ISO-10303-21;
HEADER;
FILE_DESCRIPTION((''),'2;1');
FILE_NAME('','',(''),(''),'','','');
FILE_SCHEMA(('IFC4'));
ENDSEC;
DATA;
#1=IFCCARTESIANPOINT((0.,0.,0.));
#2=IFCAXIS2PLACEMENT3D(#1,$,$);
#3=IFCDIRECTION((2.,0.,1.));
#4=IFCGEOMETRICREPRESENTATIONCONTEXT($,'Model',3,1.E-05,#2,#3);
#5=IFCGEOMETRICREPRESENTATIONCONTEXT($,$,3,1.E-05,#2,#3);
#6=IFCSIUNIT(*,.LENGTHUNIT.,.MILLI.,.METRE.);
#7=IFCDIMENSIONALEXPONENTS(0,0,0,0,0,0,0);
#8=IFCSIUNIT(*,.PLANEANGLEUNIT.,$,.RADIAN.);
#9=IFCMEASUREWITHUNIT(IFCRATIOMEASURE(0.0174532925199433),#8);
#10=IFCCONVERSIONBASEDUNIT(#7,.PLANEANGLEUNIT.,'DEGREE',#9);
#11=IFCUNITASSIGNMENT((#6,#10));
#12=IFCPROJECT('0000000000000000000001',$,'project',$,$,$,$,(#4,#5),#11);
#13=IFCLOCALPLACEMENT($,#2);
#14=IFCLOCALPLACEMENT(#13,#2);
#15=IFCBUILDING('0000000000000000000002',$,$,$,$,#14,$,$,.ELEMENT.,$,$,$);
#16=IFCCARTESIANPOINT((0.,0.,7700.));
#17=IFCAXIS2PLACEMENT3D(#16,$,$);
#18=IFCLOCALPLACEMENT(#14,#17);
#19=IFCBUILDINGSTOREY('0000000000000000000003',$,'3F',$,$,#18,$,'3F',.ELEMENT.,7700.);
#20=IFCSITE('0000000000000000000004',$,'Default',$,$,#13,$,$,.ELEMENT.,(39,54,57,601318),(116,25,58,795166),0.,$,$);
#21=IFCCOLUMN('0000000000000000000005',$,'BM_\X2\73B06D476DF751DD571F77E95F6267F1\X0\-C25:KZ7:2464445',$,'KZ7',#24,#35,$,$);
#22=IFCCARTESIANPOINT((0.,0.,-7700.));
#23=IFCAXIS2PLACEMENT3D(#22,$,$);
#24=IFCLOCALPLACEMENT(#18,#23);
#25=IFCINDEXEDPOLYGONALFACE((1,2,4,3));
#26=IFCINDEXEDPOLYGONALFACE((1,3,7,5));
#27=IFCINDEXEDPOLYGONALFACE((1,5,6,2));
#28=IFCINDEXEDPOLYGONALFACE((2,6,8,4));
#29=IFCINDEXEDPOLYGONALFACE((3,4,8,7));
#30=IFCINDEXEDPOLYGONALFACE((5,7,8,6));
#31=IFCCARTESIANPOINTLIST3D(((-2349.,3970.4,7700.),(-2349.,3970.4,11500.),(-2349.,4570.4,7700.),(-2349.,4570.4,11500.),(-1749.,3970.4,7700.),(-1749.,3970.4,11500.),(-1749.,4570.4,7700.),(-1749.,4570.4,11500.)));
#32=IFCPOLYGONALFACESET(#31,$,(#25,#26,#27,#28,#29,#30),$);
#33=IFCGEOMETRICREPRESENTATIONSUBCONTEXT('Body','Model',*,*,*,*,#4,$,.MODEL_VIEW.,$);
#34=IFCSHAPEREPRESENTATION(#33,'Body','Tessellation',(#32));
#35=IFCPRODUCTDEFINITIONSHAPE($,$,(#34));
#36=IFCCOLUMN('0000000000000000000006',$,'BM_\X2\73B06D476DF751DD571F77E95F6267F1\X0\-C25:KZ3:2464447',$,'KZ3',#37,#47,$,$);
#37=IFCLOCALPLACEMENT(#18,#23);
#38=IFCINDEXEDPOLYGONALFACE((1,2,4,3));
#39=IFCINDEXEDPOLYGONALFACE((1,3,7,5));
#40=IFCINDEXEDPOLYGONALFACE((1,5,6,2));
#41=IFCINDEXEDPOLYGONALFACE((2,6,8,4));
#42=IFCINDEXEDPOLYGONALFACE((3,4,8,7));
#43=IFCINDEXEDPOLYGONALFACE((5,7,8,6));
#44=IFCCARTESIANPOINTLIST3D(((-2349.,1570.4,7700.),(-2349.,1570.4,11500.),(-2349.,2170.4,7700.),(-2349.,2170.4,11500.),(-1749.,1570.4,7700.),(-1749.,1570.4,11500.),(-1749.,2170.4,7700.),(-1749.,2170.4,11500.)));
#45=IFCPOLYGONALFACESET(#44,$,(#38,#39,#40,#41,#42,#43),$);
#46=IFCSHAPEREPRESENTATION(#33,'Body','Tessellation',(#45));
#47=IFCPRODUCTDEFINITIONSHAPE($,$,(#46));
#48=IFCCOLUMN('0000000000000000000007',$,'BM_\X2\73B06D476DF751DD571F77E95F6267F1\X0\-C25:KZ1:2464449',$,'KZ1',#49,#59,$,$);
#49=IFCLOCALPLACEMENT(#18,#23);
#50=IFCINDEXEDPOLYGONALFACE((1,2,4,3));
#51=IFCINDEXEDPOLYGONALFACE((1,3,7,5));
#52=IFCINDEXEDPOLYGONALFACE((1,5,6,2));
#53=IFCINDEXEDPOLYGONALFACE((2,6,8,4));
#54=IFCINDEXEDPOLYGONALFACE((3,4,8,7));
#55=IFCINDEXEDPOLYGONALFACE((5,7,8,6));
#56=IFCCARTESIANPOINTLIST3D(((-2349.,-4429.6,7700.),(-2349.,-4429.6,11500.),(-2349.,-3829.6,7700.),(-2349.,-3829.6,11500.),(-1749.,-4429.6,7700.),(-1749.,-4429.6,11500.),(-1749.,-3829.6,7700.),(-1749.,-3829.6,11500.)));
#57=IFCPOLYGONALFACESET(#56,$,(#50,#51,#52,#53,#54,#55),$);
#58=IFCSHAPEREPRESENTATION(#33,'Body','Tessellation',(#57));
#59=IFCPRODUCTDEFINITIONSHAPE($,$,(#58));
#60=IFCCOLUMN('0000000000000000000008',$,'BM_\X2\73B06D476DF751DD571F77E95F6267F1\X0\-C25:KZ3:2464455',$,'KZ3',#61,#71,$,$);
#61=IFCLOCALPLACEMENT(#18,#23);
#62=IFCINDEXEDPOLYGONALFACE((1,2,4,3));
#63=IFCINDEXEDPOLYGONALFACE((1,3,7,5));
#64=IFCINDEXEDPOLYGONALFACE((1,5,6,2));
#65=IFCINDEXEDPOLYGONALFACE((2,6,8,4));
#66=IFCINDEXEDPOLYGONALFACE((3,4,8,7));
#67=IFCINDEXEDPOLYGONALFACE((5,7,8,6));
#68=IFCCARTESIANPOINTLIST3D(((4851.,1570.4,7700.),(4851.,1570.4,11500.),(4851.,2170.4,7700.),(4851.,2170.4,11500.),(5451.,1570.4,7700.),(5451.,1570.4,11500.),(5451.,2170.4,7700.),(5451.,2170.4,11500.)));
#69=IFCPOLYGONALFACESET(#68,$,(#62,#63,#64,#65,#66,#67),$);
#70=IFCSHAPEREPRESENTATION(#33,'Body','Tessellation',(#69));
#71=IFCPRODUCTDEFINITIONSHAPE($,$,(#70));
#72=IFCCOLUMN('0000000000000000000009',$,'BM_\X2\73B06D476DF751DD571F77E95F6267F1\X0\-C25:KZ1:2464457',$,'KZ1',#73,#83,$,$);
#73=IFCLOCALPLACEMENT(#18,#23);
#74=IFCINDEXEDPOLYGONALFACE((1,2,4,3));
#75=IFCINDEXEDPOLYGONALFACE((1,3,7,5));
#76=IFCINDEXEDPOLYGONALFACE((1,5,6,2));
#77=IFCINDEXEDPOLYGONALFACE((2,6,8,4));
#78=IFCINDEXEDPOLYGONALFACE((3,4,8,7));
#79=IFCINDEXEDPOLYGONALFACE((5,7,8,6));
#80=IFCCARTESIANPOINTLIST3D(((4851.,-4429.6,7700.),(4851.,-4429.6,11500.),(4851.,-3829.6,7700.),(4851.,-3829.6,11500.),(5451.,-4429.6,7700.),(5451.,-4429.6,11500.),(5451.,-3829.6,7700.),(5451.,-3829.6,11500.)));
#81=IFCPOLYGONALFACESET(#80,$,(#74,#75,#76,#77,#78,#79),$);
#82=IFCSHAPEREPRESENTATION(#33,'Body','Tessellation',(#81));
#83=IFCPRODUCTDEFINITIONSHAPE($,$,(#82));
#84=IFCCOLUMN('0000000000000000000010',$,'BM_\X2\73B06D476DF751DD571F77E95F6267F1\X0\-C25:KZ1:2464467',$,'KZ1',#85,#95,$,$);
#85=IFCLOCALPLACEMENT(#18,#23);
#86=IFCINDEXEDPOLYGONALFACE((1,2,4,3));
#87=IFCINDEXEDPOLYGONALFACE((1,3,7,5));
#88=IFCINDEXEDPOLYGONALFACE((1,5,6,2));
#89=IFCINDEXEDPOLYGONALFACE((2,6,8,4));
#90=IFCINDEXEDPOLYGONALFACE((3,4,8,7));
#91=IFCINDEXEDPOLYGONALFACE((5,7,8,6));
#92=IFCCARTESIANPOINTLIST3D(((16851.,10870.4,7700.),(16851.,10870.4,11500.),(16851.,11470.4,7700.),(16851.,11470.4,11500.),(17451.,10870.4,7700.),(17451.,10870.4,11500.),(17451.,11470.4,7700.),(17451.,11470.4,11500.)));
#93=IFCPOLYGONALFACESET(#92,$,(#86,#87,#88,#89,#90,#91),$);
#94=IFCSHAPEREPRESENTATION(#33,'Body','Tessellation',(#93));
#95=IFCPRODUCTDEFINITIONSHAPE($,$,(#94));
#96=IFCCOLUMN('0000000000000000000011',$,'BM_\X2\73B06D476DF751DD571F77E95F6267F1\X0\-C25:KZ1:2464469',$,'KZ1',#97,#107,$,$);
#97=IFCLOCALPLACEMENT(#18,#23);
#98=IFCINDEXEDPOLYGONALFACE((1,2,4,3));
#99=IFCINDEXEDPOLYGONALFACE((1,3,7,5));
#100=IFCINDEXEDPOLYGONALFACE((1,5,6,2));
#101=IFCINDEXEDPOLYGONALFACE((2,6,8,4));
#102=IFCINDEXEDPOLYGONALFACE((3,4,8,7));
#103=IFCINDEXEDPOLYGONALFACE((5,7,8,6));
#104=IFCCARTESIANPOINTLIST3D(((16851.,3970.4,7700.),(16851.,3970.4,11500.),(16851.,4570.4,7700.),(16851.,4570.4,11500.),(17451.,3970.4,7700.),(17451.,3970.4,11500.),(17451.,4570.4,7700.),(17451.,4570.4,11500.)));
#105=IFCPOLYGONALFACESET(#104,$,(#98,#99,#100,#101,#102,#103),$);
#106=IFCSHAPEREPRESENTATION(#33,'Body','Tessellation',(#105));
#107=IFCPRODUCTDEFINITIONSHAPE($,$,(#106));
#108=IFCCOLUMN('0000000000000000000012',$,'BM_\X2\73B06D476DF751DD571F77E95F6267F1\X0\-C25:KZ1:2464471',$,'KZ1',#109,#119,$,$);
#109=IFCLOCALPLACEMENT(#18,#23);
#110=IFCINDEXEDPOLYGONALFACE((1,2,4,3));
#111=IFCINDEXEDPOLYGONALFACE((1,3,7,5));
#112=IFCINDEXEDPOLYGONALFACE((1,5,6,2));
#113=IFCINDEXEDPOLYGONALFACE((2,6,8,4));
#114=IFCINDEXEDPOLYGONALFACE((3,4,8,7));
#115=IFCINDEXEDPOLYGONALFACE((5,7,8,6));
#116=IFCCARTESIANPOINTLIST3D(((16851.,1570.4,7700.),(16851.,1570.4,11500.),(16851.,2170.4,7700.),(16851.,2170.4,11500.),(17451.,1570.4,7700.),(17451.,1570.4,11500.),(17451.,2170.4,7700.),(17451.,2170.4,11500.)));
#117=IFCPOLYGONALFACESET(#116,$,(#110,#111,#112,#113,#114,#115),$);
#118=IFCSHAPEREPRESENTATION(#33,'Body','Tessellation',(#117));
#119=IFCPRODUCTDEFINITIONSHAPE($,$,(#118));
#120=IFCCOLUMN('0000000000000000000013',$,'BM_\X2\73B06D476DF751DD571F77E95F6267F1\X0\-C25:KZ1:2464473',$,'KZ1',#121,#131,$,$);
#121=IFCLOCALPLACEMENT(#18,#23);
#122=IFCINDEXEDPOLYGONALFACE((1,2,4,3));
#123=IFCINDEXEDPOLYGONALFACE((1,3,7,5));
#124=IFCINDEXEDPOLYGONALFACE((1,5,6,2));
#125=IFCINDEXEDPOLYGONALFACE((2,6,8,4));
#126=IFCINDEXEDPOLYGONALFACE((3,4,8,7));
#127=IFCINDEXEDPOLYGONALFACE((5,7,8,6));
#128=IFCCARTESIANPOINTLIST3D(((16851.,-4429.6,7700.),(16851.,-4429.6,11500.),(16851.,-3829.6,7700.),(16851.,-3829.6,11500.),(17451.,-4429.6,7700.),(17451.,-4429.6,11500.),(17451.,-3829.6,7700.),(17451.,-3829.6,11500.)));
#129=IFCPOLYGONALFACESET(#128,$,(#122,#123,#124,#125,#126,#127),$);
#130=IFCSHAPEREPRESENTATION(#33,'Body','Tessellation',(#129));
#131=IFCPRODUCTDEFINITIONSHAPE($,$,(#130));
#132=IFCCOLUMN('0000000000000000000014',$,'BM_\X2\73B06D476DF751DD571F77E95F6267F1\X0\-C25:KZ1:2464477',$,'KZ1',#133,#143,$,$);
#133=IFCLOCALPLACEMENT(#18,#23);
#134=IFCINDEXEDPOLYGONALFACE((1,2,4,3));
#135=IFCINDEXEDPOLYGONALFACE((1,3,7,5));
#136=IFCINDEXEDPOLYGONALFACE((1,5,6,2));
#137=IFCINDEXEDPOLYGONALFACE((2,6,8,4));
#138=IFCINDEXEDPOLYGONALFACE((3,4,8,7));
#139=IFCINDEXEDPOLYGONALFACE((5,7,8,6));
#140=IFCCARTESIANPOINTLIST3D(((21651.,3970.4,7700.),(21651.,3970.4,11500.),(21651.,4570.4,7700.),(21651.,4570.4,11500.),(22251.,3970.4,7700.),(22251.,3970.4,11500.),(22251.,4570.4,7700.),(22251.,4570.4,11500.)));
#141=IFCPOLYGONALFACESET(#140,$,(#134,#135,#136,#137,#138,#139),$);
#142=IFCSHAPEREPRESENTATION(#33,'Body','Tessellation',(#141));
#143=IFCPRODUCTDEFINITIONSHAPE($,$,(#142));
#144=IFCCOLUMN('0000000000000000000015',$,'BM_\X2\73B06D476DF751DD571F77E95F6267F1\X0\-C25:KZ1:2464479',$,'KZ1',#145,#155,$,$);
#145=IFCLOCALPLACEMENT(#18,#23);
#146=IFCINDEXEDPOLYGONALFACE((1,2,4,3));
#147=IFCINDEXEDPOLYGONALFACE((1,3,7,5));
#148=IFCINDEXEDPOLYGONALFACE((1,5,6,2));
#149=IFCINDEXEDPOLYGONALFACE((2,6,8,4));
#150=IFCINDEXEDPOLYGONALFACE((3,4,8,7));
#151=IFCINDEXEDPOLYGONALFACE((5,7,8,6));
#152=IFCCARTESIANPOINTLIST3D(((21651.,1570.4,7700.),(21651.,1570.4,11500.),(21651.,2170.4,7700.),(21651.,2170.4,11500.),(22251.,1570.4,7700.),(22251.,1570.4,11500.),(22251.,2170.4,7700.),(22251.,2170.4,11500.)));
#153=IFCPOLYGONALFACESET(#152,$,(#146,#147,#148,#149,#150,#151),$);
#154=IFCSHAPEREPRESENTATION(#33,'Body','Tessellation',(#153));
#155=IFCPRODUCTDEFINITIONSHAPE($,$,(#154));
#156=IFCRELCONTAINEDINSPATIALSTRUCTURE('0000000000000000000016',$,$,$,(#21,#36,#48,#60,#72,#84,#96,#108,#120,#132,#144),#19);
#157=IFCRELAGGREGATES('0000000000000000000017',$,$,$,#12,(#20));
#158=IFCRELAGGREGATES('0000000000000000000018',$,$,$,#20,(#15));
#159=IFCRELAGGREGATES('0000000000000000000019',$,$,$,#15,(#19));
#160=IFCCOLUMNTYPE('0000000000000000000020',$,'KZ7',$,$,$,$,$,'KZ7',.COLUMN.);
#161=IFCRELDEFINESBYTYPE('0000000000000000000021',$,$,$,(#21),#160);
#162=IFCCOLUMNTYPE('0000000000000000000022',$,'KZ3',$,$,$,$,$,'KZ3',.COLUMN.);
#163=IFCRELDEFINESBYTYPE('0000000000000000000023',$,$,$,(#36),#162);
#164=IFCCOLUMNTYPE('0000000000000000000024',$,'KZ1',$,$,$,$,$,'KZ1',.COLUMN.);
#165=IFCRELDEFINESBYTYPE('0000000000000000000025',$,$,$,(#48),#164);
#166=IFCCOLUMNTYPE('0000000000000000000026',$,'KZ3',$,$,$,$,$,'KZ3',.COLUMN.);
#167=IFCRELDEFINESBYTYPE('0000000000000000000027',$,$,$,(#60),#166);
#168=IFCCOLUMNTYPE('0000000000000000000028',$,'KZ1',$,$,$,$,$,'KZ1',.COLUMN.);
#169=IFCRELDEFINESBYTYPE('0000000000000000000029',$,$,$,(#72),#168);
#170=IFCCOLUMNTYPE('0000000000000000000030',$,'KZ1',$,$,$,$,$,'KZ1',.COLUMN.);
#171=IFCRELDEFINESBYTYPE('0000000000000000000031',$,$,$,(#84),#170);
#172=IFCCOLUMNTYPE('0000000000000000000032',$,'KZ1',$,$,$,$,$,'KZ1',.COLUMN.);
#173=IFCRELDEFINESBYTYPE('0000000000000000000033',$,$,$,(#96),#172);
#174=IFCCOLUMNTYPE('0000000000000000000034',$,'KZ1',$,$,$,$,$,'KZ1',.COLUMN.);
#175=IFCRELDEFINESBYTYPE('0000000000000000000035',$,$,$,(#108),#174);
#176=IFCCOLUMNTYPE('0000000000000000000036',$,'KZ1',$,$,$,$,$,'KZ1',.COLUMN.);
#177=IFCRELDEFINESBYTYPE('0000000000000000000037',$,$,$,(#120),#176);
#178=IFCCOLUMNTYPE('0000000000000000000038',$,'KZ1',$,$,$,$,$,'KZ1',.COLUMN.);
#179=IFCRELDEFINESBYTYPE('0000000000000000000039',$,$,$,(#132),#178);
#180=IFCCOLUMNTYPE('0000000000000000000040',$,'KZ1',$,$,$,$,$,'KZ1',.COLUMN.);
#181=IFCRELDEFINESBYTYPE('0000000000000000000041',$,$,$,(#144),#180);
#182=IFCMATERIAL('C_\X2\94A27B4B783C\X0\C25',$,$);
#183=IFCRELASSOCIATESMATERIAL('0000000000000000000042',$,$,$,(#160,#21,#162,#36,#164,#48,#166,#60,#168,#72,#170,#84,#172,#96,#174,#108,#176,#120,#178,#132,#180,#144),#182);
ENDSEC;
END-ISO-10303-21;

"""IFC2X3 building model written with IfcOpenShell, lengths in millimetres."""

from ifc_helpers import new_model, entity, si_unit, converted_unit, direction, frame, frame_2d, origin, origin_2d_with_axis, place, context, subcontext, project, spatial, rectangle, extrude, source, transform, mapped, material, type_object, type_shapes, element, save


model = new_model("IFC2X3")

# Units and contexts
model_context = context("Model", 3, precision=1e-05, world=origin(), true_north=direction((2.0, 0.0, 1.0)))
context_of_model = context(None, 3, precision=1e-05, world=origin(), true_north=direction((2.0, 0.0, 1.0)))
body_context = subcontext(model_context, "Body", "Model", "MODEL_VIEW")
ifc_project = project(units=[si_unit("LENGTHUNIT", "METRE", prefix="MILLI"), converted_unit("PLANEANGLEUNIT", "DEGREE", entity("IfcRatioMeasure", 0.0174532925199433), si_unit("PLANEANGLEUNIT", "RADIAN"), dimensions=[0, 0, 0, 0, 0, 0, 0])], contexts=[model_context, context_of_model])

# Site, building, storey
site_placement = place(None, origin())
site = spatial("IfcSite", under=ifc_project, at=site_placement, Name="Default", CompositionType="ELEMENT", RefLatitude=(39, 54, 57, 601318), RefLongitude=(116, 25, 58, 795166), RefElevation=0.0)
building_placement = place(site_placement, origin())
building = spatial("IfcBuilding", under=site, at=building_placement, CompositionType="ELEMENT")
storey_placement = place(building_placement, frame((0.0, 0.0, 7700.0)))
storey = spatial("IfcBuildingStorey", under=building, at=storey_placement, Name="3F", LongName="3F", CompositionType="ELEMENT", Elevation=7700.0)

# Columns
ifc_material = material(Name="C_钢筋砼C25")
column_type_1 = type_object("IfcColumnType", Name="KZ7", ElementType="KZ7", PredefinedType="COLUMN", material=ifc_material)
shared_shape_1 = source(origin(), body_context, "Body", "SweptSolid", [
    extrude(rectangle(XDim=600.0, YDim=600.0, at=origin_2d_with_axis()), frame((-2049.0, 4270.4, 7700.0), z_axis=(0.0, 0.0, 1.0), x_axis=(-1.0, 0.0, 0.0)), (0.0, 0.0, 1.0), 3800.0),
])
type_shapes(column_type_1, [shared_shape_1])
column_1_placement = place(storey_placement, frame((0.0, 0.0, -7700.0)))
element("IfcColumn", 1, at=column_1_placement, inside=storey, type_object=column_type_1, material=ifc_material, Name="BM_现浇混凝土矩形柱-C25:KZ7:2464445", ObjectType="KZ7", context=body_context, shape_type="MappedRepresentation", body=[
    mapped(shared_shape_1, transform((0.0, 0.0, 0.0), scale=1.0)),
])
column_type_2 = type_object("IfcColumnType", Name="KZ3", ElementType="KZ3", PredefinedType="COLUMN", material=ifc_material)
shared_shape_2 = source(origin(), body_context, "Body", "SweptSolid", [
    extrude(rectangle(XDim=600.0, YDim=600.0, at=origin_2d_with_axis()), frame((-2049.0, 1870.4, 7700.0), z_axis=(0.0, 0.0, 1.0), x_axis=(-1.0, 0.0, 0.0)), (0.0, 0.0, 1.0), 3800.0),
])
type_shapes(column_type_2, [shared_shape_2])
column_2_placement = place(storey_placement, frame((0.0, 0.0, -7700.0)))
element("IfcColumn", 2, at=column_2_placement, inside=storey, type_object=column_type_2, material=ifc_material, Name="BM_现浇混凝土矩形柱-C25:KZ3:2464447", ObjectType="KZ3", context=body_context, shape_type="MappedRepresentation", body=[
    mapped(shared_shape_2, transform((0.0, 0.0, 0.0), scale=1.0)),
])
column_type_3 = type_object("IfcColumnType", Name="KZ1", ElementType="KZ1", PredefinedType="COLUMN", material=ifc_material)
shared_shape_3 = source(origin(), body_context, "Body", "SweptSolid", [
    extrude(rectangle(XDim=600.0, YDim=600.0, at=origin_2d_with_axis()), frame((-2049.0, -4129.6, 7700.0), z_axis=(0.0, 0.0, 1.0), x_axis=(-1.0, 0.0, 0.0)), (0.0, 0.0, 1.0), 3800.0),
])
type_shapes(column_type_3, [shared_shape_3])
column_3_placement = place(storey_placement, frame((0.0, 0.0, -7700.0)))
element("IfcColumn", 3, at=column_3_placement, inside=storey, type_object=column_type_3, material=ifc_material, Name="BM_现浇混凝土矩形柱-C25:KZ1:2464449", ObjectType="KZ1", context=body_context, shape_type="MappedRepresentation", body=[
    mapped(shared_shape_3, transform((0.0, 0.0, 0.0), scale=1.0)),
])
column_type_4 = type_object("IfcColumnType", Name="KZ3", ElementType="KZ3", PredefinedType="COLUMN", material=ifc_material)
shared_shape_4 = source(origin(), body_context, "Body", "SweptSolid", [
    extrude(rectangle(XDim=600.0, YDim=600.0, at=origin_2d_with_axis()), frame((5151.0, 1870.4, 7700.0), z_axis=(0.0, 0.0, 1.0), x_axis=(-1.0, 0.0, 0.0)), (0.0, 0.0, 1.0), 3800.0),
])
type_shapes(column_type_4, [shared_shape_4])
column_4_placement = place(storey_placement, frame((0.0, 0.0, -7700.0)))
element("IfcColumn", 4, at=column_4_placement, inside=storey, type_object=column_type_4, material=ifc_material, Name="BM_现浇混凝土矩形柱-C25:KZ3:2464455", ObjectType="KZ3", context=body_context, shape_type="MappedRepresentation", body=[
    mapped(shared_shape_4, transform((0.0, 0.0, 0.0), scale=1.0)),
])
column_type_5 = type_object("IfcColumnType", Name="KZ1", ElementType="KZ1", PredefinedType="COLUMN", material=ifc_material)
shared_shape_5 = source(origin(), body_context, "Body", "SweptSolid", [
    extrude(rectangle(XDim=600.0, YDim=600.0, at=origin_2d_with_axis()), frame((5151.0, -4129.6, 7700.0), z_axis=(0.0, 0.0, 1.0), x_axis=(-1.0, 0.0, 0.0)), (0.0, 0.0, 1.0), 3800.0),
])
type_shapes(column_type_5, [shared_shape_5])
column_5_placement = place(storey_placement, frame((0.0, 0.0, -7700.0)))
element("IfcColumn", 5, at=column_5_placement, inside=storey, type_object=column_type_5, material=ifc_material, Name="BM_现浇混凝土矩形柱-C25:KZ1:2464457", ObjectType="KZ1", context=body_context, shape_type="MappedRepresentation", body=[
    mapped(shared_shape_5, transform((0.0, 0.0, 0.0), scale=1.0)),
])
column_type_6 = type_object("IfcColumnType", Name="KZ1", ElementType="KZ1", PredefinedType="COLUMN", material=ifc_material)
shared_shape_6 = source(origin(), body_context, "Body", "SweptSolid", [
    extrude(rectangle(XDim=600.0, YDim=600.0, at=frame_2d((0.0, 0.0), x_axis=(1.0, 0.0))), frame((17151.0, 11170.4, 7700.0), z_axis=(0.0, 0.0, 1.0), x_axis=(-1.0, 0.0, 0.0)), (0.0, 0.0, 1.0), 3800.0),
])
type_shapes(column_type_6, [shared_shape_6])
column_6_placement = place(storey_placement, frame((0.0, 0.0, -7700.0)))
element("IfcColumn", 6, at=column_6_placement, inside=storey, type_object=column_type_6, material=ifc_material, Name="BM_现浇混凝土矩形柱-C25:KZ1:2464467", ObjectType="KZ1", context=body_context, shape_type="MappedRepresentation", body=[
    mapped(shared_shape_6, transform((0.0, 0.0, 0.0), scale=1.0)),
])
column_type_7 = type_object("IfcColumnType", Name="KZ1", ElementType="KZ1", PredefinedType="COLUMN", material=ifc_material)
shared_shape_7 = source(origin(), body_context, "Body", "SweptSolid", [
    extrude(rectangle(XDim=600.0, YDim=600.0, at=frame_2d((0.0, 0.0), x_axis=(1.0, 0.0))), frame((17151.0, 4270.4, 7700.0), z_axis=(0.0, 0.0, 1.0), x_axis=(-1.0, 0.0, 0.0)), (0.0, 0.0, 1.0), 3800.0),
])
type_shapes(column_type_7, [shared_shape_7])
column_7_placement = place(storey_placement, frame((0.0, 0.0, -7700.0)))
element("IfcColumn", 7, at=column_7_placement, inside=storey, type_object=column_type_7, material=ifc_material, Name="BM_现浇混凝土矩形柱-C25:KZ1:2464469", ObjectType="KZ1", context=body_context, shape_type="MappedRepresentation", body=[
    mapped(shared_shape_7, transform((0.0, 0.0, 0.0), scale=1.0)),
])
column_type_8 = type_object("IfcColumnType", Name="KZ1", ElementType="KZ1", PredefinedType="COLUMN", material=ifc_material)
shared_shape_8 = source(origin(), body_context, "Body", "SweptSolid", [
    extrude(rectangle(XDim=600.0, YDim=600.0, at=frame_2d((0.0, 0.0), x_axis=(1.0, 0.0))), frame((17151.0, 1870.4, 7700.0), z_axis=(0.0, 0.0, 1.0), x_axis=(-1.0, 0.0, 0.0)), (0.0, 0.0, 1.0), 3800.0),
])
type_shapes(column_type_8, [shared_shape_8])
column_8_placement = place(storey_placement, frame((0.0, 0.0, -7700.0)))
element("IfcColumn", 8, at=column_8_placement, inside=storey, type_object=column_type_8, material=ifc_material, Name="BM_现浇混凝土矩形柱-C25:KZ1:2464471", ObjectType="KZ1", context=body_context, shape_type="MappedRepresentation", body=[
    mapped(shared_shape_8, transform((0.0, 0.0, 0.0), scale=1.0)),
])
column_type_9 = type_object("IfcColumnType", Name="KZ1", ElementType="KZ1", PredefinedType="COLUMN", material=ifc_material)
shared_shape_9 = source(origin(), body_context, "Body", "SweptSolid", [
    extrude(rectangle(XDim=600.0, YDim=600.0, at=frame_2d((0.0, 0.0), x_axis=(1.0, 0.0))), frame((17151.0, -4129.6, 7700.0), z_axis=(0.0, 0.0, 1.0), x_axis=(-1.0, 0.0, 0.0)), (0.0, 0.0, 1.0), 3800.0),
])
type_shapes(column_type_9, [shared_shape_9])
column_9_placement = place(storey_placement, frame((0.0, 0.0, -7700.0)))
element("IfcColumn", 9, at=column_9_placement, inside=storey, type_object=column_type_9, material=ifc_material, Name="BM_现浇混凝土矩形柱-C25:KZ1:2464473", ObjectType="KZ1", context=body_context, shape_type="MappedRepresentation", body=[
    mapped(shared_shape_9, transform((0.0, 0.0, 0.0), scale=1.0)),
])
column_type_10 = type_object("IfcColumnType", Name="KZ1", ElementType="KZ1", PredefinedType="COLUMN", material=ifc_material)
shared_shape_10 = source(origin(), body_context, "Body", "SweptSolid", [
    extrude(rectangle(XDim=600.0, YDim=600.0, at=frame_2d((0.0, 0.0), x_axis=(1.0, 0.0))), frame((21951.0, 4270.4, 7700.0), z_axis=(0.0, 0.0, 1.0), x_axis=(-1.0, 0.0, 0.0)), (0.0, 0.0, 1.0), 3800.0),
])
type_shapes(column_type_10, [shared_shape_10])
column_10_placement = place(storey_placement, frame((0.0, 0.0, -7700.0)))
element("IfcColumn", 10, at=column_10_placement, inside=storey, type_object=column_type_10, material=ifc_material, Name="BM_现浇混凝土矩形柱-C25:KZ1:2464477", ObjectType="KZ1", context=body_context, shape_type="MappedRepresentation", body=[
    mapped(shared_shape_10, transform((0.0, 0.0, 0.0), scale=1.0)),
])
column_type_11 = type_object("IfcColumnType", Name="KZ1", ElementType="KZ1", PredefinedType="COLUMN", material=ifc_material)
shared_shape_11 = source(origin(), body_context, "Body", "SweptSolid", [
    extrude(rectangle(XDim=600.0, YDim=600.0, at=frame_2d((0.0, 0.0), x_axis=(1.0, 0.0))), frame((21951.0, 1870.4, 7700.0), z_axis=(0.0, 0.0, 1.0), x_axis=(-1.0, 0.0, 0.0)), (0.0, 0.0, 1.0), 3800.0),
])
type_shapes(column_type_11, [shared_shape_11])
column_11_placement = place(storey_placement, frame((0.0, 0.0, -7700.0)))
element("IfcColumn", 11, at=column_11_placement, inside=storey, type_object=column_type_11, material=ifc_material, Name="BM_现浇混凝土矩形柱-C25:KZ1:2464479", ObjectType="KZ1", context=body_context, shape_type="MappedRepresentation", body=[
    mapped(shared_shape_11, transform((0.0, 0.0, 0.0), scale=1.0)),
])

save(model, "model.ifc")
